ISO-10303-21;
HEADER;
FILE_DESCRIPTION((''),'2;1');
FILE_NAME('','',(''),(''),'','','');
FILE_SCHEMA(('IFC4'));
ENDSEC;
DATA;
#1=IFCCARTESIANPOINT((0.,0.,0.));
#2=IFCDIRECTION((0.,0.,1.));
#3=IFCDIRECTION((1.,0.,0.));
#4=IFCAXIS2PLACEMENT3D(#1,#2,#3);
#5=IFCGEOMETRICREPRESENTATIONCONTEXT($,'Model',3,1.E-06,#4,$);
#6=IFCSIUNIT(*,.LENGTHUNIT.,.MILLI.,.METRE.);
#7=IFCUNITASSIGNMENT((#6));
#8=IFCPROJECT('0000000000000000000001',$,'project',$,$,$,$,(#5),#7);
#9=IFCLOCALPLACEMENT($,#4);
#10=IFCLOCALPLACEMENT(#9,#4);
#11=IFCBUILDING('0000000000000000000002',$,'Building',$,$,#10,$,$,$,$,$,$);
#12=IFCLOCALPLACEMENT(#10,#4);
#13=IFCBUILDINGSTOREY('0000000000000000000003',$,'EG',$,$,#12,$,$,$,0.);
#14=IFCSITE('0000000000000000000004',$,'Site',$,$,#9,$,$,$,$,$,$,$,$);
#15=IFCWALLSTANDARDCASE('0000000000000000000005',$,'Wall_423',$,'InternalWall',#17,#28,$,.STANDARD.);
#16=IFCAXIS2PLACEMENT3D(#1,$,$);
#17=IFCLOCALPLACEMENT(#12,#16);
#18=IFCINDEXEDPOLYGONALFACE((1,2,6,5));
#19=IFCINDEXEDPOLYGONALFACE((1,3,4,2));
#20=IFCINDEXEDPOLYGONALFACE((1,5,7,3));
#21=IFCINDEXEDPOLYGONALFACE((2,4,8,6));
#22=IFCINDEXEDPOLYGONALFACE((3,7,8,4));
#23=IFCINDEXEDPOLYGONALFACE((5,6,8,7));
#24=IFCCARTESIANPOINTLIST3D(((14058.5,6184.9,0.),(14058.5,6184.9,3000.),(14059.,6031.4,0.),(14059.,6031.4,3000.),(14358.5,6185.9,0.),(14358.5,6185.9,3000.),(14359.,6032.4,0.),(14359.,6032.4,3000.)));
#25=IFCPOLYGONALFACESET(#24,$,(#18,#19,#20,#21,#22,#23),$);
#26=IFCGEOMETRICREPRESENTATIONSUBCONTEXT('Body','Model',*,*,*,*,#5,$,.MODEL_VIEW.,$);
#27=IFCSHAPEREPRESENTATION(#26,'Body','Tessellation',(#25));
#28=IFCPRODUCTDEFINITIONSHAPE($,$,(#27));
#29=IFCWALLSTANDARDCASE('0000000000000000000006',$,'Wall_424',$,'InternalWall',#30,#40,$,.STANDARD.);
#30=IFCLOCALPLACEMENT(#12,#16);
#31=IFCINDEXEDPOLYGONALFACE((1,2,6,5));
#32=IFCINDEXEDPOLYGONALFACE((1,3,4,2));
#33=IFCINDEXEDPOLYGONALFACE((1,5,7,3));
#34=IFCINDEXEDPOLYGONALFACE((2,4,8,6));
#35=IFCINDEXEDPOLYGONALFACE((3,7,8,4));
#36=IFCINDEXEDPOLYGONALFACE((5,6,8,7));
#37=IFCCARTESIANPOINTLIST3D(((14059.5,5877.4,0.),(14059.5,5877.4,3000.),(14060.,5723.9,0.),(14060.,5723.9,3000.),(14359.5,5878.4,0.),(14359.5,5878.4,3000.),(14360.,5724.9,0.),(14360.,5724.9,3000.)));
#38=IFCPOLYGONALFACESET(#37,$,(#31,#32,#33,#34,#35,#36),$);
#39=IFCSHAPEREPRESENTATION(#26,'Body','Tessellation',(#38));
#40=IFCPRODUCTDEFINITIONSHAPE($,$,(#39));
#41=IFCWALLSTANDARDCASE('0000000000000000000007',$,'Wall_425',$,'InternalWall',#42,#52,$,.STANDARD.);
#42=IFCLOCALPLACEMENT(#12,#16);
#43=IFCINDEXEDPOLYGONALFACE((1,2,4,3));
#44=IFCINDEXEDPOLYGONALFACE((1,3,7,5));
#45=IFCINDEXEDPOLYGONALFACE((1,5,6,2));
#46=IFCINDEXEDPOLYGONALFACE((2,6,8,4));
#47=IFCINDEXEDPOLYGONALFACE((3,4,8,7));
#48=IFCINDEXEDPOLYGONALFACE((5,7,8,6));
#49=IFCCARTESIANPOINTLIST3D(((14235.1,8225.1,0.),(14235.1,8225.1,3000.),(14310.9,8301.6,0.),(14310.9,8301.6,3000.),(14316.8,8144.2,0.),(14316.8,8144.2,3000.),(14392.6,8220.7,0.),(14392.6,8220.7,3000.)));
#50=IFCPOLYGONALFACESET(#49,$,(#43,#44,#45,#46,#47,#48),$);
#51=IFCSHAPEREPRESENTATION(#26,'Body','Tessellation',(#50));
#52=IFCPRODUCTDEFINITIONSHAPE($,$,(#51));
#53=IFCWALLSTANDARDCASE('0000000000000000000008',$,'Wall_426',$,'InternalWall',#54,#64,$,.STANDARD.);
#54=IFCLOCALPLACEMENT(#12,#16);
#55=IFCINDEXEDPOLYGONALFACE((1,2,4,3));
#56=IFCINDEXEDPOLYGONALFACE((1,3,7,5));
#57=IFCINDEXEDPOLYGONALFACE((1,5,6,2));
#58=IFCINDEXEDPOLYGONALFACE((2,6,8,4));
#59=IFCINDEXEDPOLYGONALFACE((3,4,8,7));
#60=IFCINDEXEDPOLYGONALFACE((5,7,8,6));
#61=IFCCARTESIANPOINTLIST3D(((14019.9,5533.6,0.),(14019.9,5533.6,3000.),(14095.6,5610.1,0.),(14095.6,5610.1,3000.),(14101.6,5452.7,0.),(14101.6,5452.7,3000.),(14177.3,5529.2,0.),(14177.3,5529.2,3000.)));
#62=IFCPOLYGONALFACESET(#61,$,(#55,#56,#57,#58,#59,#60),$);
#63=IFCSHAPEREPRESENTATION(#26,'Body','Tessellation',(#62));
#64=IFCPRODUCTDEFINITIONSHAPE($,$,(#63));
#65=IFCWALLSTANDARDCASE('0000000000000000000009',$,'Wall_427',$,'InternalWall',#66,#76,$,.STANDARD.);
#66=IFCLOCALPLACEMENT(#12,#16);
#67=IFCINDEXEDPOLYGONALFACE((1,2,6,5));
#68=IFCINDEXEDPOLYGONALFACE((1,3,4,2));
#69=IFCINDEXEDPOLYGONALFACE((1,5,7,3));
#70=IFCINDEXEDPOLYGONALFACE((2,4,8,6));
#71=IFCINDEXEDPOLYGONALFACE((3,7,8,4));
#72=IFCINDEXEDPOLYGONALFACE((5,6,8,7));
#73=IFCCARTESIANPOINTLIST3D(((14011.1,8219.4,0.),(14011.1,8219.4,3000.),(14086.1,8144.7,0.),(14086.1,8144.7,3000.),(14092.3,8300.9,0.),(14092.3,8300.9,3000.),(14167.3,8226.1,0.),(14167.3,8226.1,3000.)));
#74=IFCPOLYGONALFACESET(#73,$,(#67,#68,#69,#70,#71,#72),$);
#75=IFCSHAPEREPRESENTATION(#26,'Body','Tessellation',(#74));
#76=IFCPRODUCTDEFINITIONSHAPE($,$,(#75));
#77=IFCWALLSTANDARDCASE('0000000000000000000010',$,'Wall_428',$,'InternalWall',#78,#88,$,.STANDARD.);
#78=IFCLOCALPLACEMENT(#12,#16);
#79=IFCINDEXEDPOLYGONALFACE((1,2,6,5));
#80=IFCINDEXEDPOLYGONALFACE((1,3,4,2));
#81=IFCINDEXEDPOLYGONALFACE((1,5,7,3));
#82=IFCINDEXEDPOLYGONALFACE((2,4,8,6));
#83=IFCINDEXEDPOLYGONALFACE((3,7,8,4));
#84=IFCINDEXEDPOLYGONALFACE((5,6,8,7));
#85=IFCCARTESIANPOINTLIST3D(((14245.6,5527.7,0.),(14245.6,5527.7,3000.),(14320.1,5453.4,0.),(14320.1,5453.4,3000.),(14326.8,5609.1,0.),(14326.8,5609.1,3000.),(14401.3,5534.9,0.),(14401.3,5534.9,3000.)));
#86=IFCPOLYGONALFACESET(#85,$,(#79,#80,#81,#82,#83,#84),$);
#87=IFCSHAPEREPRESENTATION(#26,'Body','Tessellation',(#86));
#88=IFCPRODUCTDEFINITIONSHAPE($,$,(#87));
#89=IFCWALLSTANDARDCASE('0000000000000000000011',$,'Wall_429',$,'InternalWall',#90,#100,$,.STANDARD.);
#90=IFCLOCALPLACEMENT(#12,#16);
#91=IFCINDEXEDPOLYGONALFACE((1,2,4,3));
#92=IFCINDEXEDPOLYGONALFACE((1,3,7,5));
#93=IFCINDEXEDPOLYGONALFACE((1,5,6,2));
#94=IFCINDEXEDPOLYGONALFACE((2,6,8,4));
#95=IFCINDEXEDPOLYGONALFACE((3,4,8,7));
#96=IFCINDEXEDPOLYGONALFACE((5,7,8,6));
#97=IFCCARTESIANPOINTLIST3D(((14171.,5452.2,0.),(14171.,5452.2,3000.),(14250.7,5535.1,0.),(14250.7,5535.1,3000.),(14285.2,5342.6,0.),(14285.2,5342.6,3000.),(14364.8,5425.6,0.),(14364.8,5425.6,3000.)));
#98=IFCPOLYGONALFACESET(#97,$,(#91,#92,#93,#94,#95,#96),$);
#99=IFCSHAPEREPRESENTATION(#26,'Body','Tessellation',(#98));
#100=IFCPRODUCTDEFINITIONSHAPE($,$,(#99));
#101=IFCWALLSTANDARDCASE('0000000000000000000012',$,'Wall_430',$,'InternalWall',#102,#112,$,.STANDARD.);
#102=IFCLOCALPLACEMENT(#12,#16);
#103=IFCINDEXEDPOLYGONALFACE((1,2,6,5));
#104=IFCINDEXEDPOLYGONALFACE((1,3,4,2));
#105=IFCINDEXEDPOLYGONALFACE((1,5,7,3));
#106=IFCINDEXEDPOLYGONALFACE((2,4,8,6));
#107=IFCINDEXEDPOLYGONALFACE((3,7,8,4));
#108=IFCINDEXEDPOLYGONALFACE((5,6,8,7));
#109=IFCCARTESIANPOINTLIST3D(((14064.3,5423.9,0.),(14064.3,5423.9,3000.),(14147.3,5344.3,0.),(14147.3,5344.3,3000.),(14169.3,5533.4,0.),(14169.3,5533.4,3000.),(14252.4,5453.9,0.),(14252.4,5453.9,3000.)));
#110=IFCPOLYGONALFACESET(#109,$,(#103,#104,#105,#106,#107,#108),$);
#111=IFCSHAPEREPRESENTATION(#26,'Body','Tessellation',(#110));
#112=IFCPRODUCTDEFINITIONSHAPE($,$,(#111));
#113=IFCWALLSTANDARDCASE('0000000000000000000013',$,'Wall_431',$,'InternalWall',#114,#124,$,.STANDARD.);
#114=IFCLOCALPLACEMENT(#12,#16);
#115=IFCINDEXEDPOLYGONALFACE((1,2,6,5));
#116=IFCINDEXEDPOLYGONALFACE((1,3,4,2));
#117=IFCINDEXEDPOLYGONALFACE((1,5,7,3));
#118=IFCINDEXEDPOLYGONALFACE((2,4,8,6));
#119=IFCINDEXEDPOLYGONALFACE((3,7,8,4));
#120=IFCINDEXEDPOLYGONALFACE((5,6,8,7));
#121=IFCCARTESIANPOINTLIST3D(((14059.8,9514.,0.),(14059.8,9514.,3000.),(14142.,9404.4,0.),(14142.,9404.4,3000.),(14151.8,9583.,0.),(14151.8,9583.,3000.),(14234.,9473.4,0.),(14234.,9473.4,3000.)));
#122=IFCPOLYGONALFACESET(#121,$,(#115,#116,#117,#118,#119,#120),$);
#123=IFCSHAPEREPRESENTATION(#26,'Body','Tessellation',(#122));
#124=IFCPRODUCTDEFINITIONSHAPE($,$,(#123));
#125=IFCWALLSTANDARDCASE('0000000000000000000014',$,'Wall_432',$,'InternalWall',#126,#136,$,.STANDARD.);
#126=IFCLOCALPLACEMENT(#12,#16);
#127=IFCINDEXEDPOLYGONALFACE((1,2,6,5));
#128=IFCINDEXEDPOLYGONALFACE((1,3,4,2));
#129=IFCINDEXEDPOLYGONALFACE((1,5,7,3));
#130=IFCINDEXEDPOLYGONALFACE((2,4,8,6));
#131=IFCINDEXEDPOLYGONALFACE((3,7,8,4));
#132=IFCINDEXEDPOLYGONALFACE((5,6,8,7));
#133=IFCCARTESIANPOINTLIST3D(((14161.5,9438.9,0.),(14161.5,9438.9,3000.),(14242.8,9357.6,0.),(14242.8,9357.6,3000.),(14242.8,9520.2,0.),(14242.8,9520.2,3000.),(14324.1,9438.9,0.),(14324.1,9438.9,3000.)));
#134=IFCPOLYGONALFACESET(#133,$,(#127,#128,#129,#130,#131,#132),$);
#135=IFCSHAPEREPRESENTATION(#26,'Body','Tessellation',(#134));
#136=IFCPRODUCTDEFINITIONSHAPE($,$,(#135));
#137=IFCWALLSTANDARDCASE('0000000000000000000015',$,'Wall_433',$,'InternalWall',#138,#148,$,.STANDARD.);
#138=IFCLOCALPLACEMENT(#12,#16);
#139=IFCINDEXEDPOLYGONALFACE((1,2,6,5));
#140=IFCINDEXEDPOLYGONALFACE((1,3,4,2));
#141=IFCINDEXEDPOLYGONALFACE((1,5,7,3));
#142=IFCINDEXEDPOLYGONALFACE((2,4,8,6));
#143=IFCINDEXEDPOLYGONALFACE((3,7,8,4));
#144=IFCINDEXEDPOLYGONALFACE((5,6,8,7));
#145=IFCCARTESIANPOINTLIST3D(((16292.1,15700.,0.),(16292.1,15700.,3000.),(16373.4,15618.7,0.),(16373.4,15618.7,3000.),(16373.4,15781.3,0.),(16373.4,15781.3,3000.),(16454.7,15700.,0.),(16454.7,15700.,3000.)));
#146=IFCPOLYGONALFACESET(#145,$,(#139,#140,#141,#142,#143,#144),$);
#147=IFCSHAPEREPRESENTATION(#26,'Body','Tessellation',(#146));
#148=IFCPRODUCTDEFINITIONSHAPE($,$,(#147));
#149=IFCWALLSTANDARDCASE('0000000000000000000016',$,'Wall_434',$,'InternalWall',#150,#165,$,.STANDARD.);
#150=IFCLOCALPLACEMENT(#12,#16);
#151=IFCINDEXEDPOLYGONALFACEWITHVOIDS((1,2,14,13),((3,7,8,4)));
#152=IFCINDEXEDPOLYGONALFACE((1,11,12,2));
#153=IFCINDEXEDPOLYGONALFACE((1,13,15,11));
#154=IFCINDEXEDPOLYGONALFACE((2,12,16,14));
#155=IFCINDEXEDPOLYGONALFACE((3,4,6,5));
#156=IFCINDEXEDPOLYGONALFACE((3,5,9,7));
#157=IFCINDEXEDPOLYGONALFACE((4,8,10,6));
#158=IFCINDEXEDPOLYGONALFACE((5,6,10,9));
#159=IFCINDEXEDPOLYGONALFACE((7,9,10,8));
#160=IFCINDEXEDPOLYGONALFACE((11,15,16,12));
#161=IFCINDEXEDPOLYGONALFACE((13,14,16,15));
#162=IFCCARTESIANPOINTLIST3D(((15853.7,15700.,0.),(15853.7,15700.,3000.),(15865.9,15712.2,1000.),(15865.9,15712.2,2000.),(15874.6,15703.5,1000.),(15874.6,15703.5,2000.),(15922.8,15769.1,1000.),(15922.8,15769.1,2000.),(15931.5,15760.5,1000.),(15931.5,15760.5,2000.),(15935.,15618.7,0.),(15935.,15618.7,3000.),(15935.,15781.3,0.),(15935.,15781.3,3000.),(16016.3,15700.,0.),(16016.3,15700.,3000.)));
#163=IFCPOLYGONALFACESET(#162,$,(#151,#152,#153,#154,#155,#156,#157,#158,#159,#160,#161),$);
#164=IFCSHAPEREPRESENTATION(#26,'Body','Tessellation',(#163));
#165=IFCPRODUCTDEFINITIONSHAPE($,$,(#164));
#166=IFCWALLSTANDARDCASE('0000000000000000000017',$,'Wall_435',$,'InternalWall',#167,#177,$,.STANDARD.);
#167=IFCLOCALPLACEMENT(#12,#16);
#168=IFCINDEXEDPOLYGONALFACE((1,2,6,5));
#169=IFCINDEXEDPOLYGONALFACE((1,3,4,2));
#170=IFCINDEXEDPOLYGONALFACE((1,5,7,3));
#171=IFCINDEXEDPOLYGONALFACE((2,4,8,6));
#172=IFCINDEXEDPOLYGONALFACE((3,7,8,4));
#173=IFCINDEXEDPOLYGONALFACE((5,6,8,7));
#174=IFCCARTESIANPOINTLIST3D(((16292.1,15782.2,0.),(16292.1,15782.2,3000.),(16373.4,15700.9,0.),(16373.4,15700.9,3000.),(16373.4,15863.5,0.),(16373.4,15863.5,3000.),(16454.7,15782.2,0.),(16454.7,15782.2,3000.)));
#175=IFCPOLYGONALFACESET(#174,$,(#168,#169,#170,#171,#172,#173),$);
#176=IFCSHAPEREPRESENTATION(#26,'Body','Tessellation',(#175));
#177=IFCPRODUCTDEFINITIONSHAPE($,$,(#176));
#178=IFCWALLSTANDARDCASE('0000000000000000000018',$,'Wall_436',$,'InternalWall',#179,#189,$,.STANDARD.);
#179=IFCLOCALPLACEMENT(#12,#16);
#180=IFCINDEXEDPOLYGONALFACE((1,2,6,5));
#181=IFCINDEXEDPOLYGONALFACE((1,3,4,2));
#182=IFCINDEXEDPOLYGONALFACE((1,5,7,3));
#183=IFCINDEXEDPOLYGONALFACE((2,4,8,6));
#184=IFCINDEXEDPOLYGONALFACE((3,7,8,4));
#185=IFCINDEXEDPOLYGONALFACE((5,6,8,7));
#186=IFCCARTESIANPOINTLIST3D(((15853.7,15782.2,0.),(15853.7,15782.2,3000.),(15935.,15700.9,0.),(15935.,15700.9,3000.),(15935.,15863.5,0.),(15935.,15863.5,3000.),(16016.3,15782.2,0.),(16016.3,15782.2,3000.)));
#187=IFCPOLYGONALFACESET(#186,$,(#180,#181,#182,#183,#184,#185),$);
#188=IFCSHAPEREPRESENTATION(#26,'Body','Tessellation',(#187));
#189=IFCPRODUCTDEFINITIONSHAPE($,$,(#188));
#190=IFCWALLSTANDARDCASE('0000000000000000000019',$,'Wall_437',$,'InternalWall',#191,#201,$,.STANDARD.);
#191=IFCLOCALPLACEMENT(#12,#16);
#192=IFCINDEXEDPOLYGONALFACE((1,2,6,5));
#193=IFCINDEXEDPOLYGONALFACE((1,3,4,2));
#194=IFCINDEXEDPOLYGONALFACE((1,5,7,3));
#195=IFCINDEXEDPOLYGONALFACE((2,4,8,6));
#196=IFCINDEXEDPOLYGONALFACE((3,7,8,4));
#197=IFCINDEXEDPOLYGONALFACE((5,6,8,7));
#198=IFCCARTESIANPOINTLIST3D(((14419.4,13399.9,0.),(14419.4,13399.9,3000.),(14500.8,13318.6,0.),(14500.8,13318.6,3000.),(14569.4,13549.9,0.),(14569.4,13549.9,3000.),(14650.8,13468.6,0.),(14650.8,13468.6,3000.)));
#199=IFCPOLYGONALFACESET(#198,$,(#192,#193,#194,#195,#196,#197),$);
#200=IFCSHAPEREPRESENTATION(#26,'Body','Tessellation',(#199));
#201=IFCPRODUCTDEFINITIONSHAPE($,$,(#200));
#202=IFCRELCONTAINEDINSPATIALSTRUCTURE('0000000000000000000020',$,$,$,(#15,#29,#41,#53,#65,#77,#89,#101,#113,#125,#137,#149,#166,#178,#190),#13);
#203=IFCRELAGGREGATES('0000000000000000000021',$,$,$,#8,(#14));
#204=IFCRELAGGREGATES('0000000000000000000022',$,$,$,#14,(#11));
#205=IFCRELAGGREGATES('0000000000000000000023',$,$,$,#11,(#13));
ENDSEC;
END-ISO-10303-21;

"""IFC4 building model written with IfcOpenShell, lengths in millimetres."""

from ifc_helpers import new_model, si_unit, frame, origin_with_axes, place, context, subcontext, project, spatial, rectangle, extrude, element, save


model = new_model("IFC4")

# Units and contexts
model_context = context("Model", 3, precision=1e-06, world=origin_with_axes())
body_context = subcontext(model_context, "Body", "Model", "MODEL_VIEW")
ifc_project = project(units=[si_unit("LENGTHUNIT", "METRE", prefix="MILLI")], contexts=[model_context])

# Site, building, storey
site_placement = place(None, origin_with_axes())
site = spatial("IfcSite", under=ifc_project, at=site_placement, Name="Site")
building_placement = place(site_placement, origin_with_axes())
building = spatial("IfcBuilding", under=site, at=building_placement, Name="Building")
storey_placement = place(building_placement, origin_with_axes())
storey = spatial("IfcBuildingStorey", under=building, at=storey_placement, Name="EG", Elevation=0.0)

# Walls
wall_1_placement = place(storey_placement, origin_with_axes())
element("IfcWallStandardCase", 1, at=wall_1_placement, inside=storey, Name="Wall_423", ObjectType="InternalWall", PredefinedType="STANDARD", context=body_context, shape_type="SweptSolid", body=[
    extrude(rectangle(XDim=153.5, YDim=300.0), frame((14208.7, 6108.6, 0.0), z_axis=(0.0, 0.0, 1.0), x_axis=(0.003257, -0.999995, 0.0)), (0.0, 0.0, 1.0), 3000.0),
])
wall_2_placement = place(storey_placement, origin_with_axes())
element("IfcWallStandardCase", 2, at=wall_2_placement, inside=storey, Name="Wall_424", ObjectType="InternalWall", PredefinedType="STANDARD", context=body_context, shape_type="SweptSolid", body=[
    extrude(rectangle(XDim=153.5, YDim=300.0), frame((14209.7, 5801.1, 0.0), z_axis=(0.0, 0.0, 1.0), x_axis=(0.003257, -0.999995, 0.0)), (0.0, 0.0, 1.0), 3000.0),
])
wall_3_placement = place(storey_placement, origin_with_axes())
element("IfcWallStandardCase", 3, at=wall_3_placement, inside=storey, Name="Wall_425", ObjectType="InternalWall", PredefinedType="STANDARD", context=body_context, shape_type="SweptSolid", body=[
    extrude(rectangle(XDim=107.7, YDim=115.0), frame((14313.8, 8222.9, 0.0), z_axis=(0.0, 0.0, 1.0), x_axis=(-0.703615, -0.710581, 0.0)), (0.0, 0.0, 1.0), 3000.0),
])
wall_4_placement = place(storey_placement, origin_with_axes())
element("IfcWallStandardCase", 4, at=wall_4_placement, inside=storey, Name="Wall_426", ObjectType="InternalWall", PredefinedType="STANDARD", context=body_context, shape_type="SweptSolid", body=[
    extrude(rectangle(XDim=107.7, YDim=115.0), frame((14098.6, 5531.4, 0.0), z_axis=(0.0, 0.0, 1.0), x_axis=(-0.703615, -0.710581, 0.0)), (0.0, 0.0, 1.0), 3000.0),
])
wall_5_placement = place(storey_placement, origin_with_axes())
element("IfcWallStandardCase", 5, at=wall_5_placement, inside=storey, Name="Wall_427", ObjectType="InternalWall", PredefinedType="STANDARD", context=body_context, shape_type="SweptSolid", body=[
    extrude(rectangle(XDim=105.9, YDim=115.0), frame((14089.2, 8222.8, 0.0), z_axis=(0.0, 0.0, 1.0), x_axis=(0.708286, -0.705925, 0.0)), (0.0, 0.0, 1.0), 3000.0),
])
wall_6_placement = place(storey_placement, origin_with_axes())
element("IfcWallStandardCase", 6, at=wall_6_placement, inside=storey, Name="Wall_428", ObjectType="InternalWall", PredefinedType="STANDARD", context=body_context, shape_type="SweptSolid", body=[
    extrude(rectangle(XDim=105.2, YDim=115.0), frame((14323.5, 5531.3, 0.0), z_axis=(0.0, 0.0, 1.0), x_axis=(0.708294, -0.705917, 0.0)), (0.0, 0.0, 1.0), 3000.0),
])
wall_7_placement = place(storey_placement, origin_with_axes())
element("IfcWallStandardCase", 7, at=wall_7_placement, inside=storey, Name="Wall_429", ObjectType="InternalWall", PredefinedType="STANDARD", context=body_context, shape_type="SweptSolid", body=[
    extrude(rectangle(XDim=158.2, YDim=115.0), frame((14267.9, 5438.9, 0.0), z_axis=(0.0, 0.0, 1.0), x_axis=(-0.721459, 0.692457, 0.0)), (0.0, 0.0, 1.0), 3000.0),
])
wall_8_placement = place(storey_placement, origin_with_axes())
element("IfcWallStandardCase", 8, at=wall_8_placement, inside=storey, Name="Wall_430", ObjectType="InternalWall", PredefinedType="STANDARD", context=body_context, shape_type="SweptSolid", body=[
    extrude(rectangle(XDim=151.8, YDim=115.0), frame((14158.3, 5438.9, 0.0), z_axis=(0.0, 0.0, 1.0), x_axis=(-0.69198, -0.721917, 0.0)), (0.0, 0.0, 1.0), 3000.0),
])
wall_9_placement = place(storey_placement, origin_with_axes())
element("IfcWallStandardCase", 9, at=wall_9_placement, inside=storey, Name="Wall_431", ObjectType="InternalWall", PredefinedType="STANDARD", context=body_context, shape_type="SweptSolid", body=[
    extrude(rectangle(XDim=137.0, YDim=115.0), frame((14146.9, 9493.7, 0.0), z_axis=(0.0, 0.0, 1.0), x_axis=(-0.6, 0.8, 0.0)), (0.0, 0.0, 1.0), 3000.0),
])
wall_10_placement = place(storey_placement, origin_with_axes())
element("IfcWallStandardCase", 10, at=wall_10_placement, inside=storey, Name="Wall_432", ObjectType="InternalWall", PredefinedType="STANDARD", context=body_context, shape_type="SweptSolid", body=[
    extrude(rectangle(XDim=115.0, YDim=115.0), frame((14242.8, 9438.9, 0.0), z_axis=(0.0, 0.0, 1.0), x_axis=(-0.707107, 0.707107, 0.0)), (0.0, 0.0, 1.0), 3000.0),
])
wall_11_placement = place(storey_placement, origin_with_axes())
element("IfcWallStandardCase", 11, at=wall_11_placement, inside=storey, Name="Wall_433", ObjectType="InternalWall", PredefinedType="STANDARD", context=body_context, shape_type="SweptSolid", body=[
    extrude(rectangle(XDim=115.0, YDim=115.0), frame((16373.4, 15700.0, 0.0), z_axis=(0.0, 0.0, 1.0), x_axis=(0.707107, 0.707107, 0.0)), (0.0, 0.0, 1.0), 3000.0),
])

# Wall, opening
wall_12_placement = place(storey_placement, origin_with_axes())
wall_12 = element("IfcWallStandardCase", 12, at=wall_12_placement, inside=storey, Name="Wall_434", ObjectType="InternalWall", PredefinedType="STANDARD", context=body_context, shape_type="SweptSolid", body=[
    extrude(rectangle(XDim=115.0, YDim=115.0), frame((15935.0, 15700.0, 0.0), z_axis=(0.0, 0.0, 1.0), x_axis=(-0.707107, 0.707107, 0.0)), (0.0, 0.0, 1.0), 3000.0),
])
opening_placement = place(wall_12_placement, origin_with_axes())
element("IfcOpeningElement", 13, at=opening_placement, inside=storey, cuts=wall_12, context=body_context, shape_type="SweptSolid", body=[
    extrude(rectangle(XDim=814.3, YDim=80.5), frame((15615.1, 16019.9, 1000.0), z_axis=(0.0, 0.0, 1.0), x_axis=(-0.707107, 0.707107, 0.0)), (0.0, 0.0, 1.0), 1000.0),
])

# Walls
wall_13_placement = place(storey_placement, origin_with_axes())
element("IfcWallStandardCase", 14, at=wall_13_placement, inside=storey, Name="Wall_435", ObjectType="InternalWall", PredefinedType="STANDARD", context=body_context, shape_type="SweptSolid", body=[
    extrude(rectangle(XDim=115.0, YDim=115.0), frame((16373.4, 15782.2, 0.0), z_axis=(0.0, 0.0, 1.0), x_axis=(-0.707107, 0.707107, 0.0)), (0.0, 0.0, 1.0), 3000.0),
])
wall_14_placement = place(storey_placement, origin_with_axes())
element("IfcWallStandardCase", 15, at=wall_14_placement, inside=storey, Name="Wall_436", ObjectType="InternalWall", PredefinedType="STANDARD", context=body_context, shape_type="SweptSolid", body=[
    extrude(rectangle(XDim=115.0, YDim=115.0), frame((15935.0, 15782.2, 0.0), z_axis=(0.0, 0.0, 1.0), x_axis=(0.707107, 0.707107, 0.0)), (0.0, 0.0, 1.0), 3000.0),
])
wall_15_placement = place(storey_placement, origin_with_axes())
element("IfcWallStandardCase", 16, at=wall_15_placement, inside=storey, Name="Wall_437", ObjectType="InternalWall", PredefinedType="STANDARD", context=body_context, shape_type="SweptSolid", body=[
    extrude(rectangle(XDim=212.1, YDim=115.0), frame((14535.1, 13434.3, 0.0), z_axis=(0.0, 0.0, 1.0), x_axis=(-0.707107, -0.707107, 0.0)), (0.0, 0.0, 1.0), 3000.0),
])

save(model, "model.ifc")
